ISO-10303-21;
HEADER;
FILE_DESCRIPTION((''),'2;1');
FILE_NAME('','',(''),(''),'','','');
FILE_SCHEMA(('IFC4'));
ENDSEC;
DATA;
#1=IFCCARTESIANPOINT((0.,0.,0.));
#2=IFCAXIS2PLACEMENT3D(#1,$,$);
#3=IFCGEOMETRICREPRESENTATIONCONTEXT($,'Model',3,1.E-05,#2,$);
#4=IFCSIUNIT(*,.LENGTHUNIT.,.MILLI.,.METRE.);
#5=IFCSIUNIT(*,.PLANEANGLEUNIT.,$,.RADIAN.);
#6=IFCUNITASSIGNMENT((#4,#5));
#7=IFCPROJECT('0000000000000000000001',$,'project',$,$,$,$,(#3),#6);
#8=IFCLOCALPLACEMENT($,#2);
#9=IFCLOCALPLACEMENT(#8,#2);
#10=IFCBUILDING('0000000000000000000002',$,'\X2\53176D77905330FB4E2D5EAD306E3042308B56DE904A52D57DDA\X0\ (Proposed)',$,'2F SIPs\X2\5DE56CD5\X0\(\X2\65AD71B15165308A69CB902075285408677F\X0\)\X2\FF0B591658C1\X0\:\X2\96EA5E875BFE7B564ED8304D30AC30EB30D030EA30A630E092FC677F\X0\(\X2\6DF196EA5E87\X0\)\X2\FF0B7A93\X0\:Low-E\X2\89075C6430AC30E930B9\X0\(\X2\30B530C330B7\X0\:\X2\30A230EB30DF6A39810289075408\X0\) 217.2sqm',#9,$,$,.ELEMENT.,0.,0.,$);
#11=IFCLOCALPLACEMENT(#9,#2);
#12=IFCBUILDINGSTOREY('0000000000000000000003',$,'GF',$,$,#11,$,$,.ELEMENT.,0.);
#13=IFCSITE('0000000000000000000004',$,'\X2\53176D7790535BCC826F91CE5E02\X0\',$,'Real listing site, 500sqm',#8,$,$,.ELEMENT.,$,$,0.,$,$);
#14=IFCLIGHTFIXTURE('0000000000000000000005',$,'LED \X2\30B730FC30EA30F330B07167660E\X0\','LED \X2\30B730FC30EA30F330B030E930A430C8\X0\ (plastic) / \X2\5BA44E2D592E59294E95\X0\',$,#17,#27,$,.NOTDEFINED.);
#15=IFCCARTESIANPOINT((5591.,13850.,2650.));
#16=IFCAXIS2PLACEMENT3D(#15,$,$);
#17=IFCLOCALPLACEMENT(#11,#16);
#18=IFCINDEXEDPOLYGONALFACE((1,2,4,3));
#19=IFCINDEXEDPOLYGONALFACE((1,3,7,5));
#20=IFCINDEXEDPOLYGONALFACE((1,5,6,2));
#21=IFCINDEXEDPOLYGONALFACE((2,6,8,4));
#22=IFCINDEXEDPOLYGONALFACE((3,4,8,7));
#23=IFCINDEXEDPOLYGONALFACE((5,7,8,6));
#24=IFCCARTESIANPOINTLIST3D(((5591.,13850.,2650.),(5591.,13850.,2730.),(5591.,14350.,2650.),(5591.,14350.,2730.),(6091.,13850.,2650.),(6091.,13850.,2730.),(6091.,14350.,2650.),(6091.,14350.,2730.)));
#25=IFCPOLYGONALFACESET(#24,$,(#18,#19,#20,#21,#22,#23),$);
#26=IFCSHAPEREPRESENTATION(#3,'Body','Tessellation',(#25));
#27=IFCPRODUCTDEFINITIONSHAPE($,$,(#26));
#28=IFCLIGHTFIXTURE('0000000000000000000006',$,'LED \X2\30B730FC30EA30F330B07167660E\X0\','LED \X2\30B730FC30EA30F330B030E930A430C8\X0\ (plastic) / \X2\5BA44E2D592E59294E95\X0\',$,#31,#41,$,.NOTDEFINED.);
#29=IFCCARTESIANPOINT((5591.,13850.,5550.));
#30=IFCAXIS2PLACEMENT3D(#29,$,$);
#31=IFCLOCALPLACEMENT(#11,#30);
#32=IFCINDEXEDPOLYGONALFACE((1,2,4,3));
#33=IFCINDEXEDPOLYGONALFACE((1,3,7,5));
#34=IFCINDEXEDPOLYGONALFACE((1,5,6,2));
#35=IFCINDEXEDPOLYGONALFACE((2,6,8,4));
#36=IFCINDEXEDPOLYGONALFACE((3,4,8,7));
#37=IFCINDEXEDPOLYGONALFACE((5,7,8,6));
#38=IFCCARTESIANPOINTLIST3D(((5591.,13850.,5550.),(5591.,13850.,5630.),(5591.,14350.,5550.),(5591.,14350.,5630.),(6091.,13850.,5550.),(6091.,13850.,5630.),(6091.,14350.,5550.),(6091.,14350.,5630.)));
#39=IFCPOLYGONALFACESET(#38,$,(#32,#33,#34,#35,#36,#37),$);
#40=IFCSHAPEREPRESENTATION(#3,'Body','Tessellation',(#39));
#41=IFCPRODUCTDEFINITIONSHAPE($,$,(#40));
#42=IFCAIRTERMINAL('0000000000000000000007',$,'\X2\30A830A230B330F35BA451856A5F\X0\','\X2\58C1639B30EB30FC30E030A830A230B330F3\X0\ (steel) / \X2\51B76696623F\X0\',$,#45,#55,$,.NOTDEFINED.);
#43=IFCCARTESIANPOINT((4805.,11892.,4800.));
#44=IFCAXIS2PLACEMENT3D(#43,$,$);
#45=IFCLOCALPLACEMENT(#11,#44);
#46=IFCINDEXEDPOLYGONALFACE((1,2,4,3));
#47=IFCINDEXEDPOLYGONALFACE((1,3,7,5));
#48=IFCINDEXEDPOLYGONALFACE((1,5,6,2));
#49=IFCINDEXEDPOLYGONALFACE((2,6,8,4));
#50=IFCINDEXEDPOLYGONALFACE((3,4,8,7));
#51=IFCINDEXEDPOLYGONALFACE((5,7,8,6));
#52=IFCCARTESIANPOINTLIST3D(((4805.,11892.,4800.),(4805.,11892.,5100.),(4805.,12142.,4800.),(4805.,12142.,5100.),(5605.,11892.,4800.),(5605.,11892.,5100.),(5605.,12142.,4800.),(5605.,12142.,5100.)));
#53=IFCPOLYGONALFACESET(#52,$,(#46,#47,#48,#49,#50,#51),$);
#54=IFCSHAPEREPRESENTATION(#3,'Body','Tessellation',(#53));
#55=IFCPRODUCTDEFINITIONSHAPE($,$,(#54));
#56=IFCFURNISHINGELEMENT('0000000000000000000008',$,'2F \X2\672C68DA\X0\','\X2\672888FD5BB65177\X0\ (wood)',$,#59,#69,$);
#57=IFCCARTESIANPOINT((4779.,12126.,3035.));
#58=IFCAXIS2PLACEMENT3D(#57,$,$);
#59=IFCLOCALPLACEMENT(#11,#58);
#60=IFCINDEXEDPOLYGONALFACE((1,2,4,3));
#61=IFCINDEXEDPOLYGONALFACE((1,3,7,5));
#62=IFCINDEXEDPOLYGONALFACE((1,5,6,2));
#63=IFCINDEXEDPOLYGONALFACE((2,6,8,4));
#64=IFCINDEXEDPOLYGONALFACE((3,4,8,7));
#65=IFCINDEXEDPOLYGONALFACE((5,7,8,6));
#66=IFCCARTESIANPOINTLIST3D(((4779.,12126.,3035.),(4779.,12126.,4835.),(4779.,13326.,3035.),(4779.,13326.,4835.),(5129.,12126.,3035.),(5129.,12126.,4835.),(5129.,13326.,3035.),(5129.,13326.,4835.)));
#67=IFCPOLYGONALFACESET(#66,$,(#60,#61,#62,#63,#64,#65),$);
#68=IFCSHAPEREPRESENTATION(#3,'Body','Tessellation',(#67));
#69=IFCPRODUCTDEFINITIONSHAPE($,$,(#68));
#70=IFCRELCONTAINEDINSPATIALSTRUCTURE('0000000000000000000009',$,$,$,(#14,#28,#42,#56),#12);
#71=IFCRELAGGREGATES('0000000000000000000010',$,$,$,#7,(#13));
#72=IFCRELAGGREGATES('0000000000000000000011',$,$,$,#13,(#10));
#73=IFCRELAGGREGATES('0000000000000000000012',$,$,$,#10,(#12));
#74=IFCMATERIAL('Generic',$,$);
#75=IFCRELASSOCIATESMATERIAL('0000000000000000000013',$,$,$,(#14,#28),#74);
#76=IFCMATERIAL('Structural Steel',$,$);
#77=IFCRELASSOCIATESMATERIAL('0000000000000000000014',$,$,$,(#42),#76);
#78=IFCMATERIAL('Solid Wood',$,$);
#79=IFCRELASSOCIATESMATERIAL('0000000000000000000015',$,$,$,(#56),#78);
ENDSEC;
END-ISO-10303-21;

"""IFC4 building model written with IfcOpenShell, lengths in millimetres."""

from ifc_helpers import new_model, si_unit, frame, frame_2d, origin, place, context, project, spatial, rectangle, extrude, material, element, save


model = new_model("IFC4")

# Units and contexts
model_context = context("Model", 3, precision=1e-05, world=origin())
ifc_project = project(units=[si_unit("LENGTHUNIT", "METRE", prefix="MILLI"), si_unit("PLANEANGLEUNIT", "RADIAN")], contexts=[model_context])

# Site, building, storey
site_placement = place(None, origin())
site = spatial("IfcSite", under=ifc_project, at=site_placement, Name="北海道富良野市", ObjectType="Real listing site, 500sqm", CompositionType="ELEMENT", RefElevation=0.0)
building_placement = place(site_placement, origin())
building = spatial("IfcBuilding", under=site, at=building_placement, Name="北海道・中庭のある回遊動線 (Proposed)", ObjectType="2F SIPs工法(断熱入り構造用合板)＋外壁:雪庇対策付きガルバリウム鋼板(深雪庇)＋窓:Low-E複層ガラス(サッシ:アルミ樹脂複合) 217.2sqm", CompositionType="ELEMENT", ElevationOfRefHeight=0.0, ElevationOfTerrain=0.0)
storey_placement = place(building_placement, origin())
storey = spatial("IfcBuildingStorey", under=building, at=storey_placement, Name="GF", CompositionType="ELEMENT", Elevation=0.0)

# Shared definitions
ifc_material_1 = material(Name="Solid Wood")

# Shared definitions
ifc_material_2 = material(Name="Structural Steel")

# Shared definitions
ifc_material_3 = material(Name="Generic")

# Light fixtures
light_fixture_1_placement = place(storey_placement, frame((5591.0, 13850.0, 2650.0)))
element("IfcLightFixture", 1, at=light_fixture_1_placement, inside=storey, material=ifc_material_3, Name="LED シーリング照明", Description="LED シーリングライト (plastic) / 室中央天井", PredefinedType="NOTDEFINED", context=model_context, shape_type="SweptSolid", body=[
    extrude(rectangle(XDim=500.0, YDim=500.0, at=frame_2d((250.0, 250.0))), frame((5591.0, 13850.0, 2650.0)), (0.0, 0.0, 1.0), 80.0),
])
light_fixture_2_placement = place(storey_placement, frame((5591.0, 13850.0, 5550.0)))
element("IfcLightFixture", 2, at=light_fixture_2_placement, inside=storey, material=ifc_material_3, Name="LED シーリング照明", Description="LED シーリングライト (plastic) / 室中央天井", PredefinedType="NOTDEFINED", context=model_context, shape_type="SweptSolid", body=[
    extrude(rectangle(XDim=500.0, YDim=500.0, at=frame_2d((250.0, 250.0))), frame((5591.0, 13850.0, 5550.0)), (0.0, 0.0, 1.0), 80.0),
])

# Air terminal
air_terminal_placement = place(storey_placement, frame((4805.0, 11892.0, 4800.0)))
element("IfcAirTerminal", 3, at=air_terminal_placement, inside=storey, material=ifc_material_2, Name="エアコン室内機", Description="壁掛ルームエアコン (steel) / 冷暖房", PredefinedType="NOTDEFINED", context=model_context, shape_type="SweptSolid", body=[
    extrude(rectangle(XDim=800.0, YDim=250.0, at=frame_2d((400.0, 125.0))), frame((4805.0, 11892.0, 4800.0)), (0.0, 0.0, 1.0), 300.0),
])

# Furnishing element
furnishing_placement = place(storey_placement, frame((4779.0, 12126.0, 3035.0)))
element("IfcFurnishingElement", 4, at=furnishing_placement, inside=storey, material=ifc_material_1, Name="2F 本棚", Description="木製家具 (wood)", context=model_context, shape_type="SweptSolid", body=[
    extrude(rectangle(XDim=350.0, YDim=1200.0, at=frame_2d((175.0, 600.0))), frame((4779.0, 12126.0, 3035.0)), (0.0, 0.0, 1.0), 1800.0),
])

save(model, "model.ifc")
